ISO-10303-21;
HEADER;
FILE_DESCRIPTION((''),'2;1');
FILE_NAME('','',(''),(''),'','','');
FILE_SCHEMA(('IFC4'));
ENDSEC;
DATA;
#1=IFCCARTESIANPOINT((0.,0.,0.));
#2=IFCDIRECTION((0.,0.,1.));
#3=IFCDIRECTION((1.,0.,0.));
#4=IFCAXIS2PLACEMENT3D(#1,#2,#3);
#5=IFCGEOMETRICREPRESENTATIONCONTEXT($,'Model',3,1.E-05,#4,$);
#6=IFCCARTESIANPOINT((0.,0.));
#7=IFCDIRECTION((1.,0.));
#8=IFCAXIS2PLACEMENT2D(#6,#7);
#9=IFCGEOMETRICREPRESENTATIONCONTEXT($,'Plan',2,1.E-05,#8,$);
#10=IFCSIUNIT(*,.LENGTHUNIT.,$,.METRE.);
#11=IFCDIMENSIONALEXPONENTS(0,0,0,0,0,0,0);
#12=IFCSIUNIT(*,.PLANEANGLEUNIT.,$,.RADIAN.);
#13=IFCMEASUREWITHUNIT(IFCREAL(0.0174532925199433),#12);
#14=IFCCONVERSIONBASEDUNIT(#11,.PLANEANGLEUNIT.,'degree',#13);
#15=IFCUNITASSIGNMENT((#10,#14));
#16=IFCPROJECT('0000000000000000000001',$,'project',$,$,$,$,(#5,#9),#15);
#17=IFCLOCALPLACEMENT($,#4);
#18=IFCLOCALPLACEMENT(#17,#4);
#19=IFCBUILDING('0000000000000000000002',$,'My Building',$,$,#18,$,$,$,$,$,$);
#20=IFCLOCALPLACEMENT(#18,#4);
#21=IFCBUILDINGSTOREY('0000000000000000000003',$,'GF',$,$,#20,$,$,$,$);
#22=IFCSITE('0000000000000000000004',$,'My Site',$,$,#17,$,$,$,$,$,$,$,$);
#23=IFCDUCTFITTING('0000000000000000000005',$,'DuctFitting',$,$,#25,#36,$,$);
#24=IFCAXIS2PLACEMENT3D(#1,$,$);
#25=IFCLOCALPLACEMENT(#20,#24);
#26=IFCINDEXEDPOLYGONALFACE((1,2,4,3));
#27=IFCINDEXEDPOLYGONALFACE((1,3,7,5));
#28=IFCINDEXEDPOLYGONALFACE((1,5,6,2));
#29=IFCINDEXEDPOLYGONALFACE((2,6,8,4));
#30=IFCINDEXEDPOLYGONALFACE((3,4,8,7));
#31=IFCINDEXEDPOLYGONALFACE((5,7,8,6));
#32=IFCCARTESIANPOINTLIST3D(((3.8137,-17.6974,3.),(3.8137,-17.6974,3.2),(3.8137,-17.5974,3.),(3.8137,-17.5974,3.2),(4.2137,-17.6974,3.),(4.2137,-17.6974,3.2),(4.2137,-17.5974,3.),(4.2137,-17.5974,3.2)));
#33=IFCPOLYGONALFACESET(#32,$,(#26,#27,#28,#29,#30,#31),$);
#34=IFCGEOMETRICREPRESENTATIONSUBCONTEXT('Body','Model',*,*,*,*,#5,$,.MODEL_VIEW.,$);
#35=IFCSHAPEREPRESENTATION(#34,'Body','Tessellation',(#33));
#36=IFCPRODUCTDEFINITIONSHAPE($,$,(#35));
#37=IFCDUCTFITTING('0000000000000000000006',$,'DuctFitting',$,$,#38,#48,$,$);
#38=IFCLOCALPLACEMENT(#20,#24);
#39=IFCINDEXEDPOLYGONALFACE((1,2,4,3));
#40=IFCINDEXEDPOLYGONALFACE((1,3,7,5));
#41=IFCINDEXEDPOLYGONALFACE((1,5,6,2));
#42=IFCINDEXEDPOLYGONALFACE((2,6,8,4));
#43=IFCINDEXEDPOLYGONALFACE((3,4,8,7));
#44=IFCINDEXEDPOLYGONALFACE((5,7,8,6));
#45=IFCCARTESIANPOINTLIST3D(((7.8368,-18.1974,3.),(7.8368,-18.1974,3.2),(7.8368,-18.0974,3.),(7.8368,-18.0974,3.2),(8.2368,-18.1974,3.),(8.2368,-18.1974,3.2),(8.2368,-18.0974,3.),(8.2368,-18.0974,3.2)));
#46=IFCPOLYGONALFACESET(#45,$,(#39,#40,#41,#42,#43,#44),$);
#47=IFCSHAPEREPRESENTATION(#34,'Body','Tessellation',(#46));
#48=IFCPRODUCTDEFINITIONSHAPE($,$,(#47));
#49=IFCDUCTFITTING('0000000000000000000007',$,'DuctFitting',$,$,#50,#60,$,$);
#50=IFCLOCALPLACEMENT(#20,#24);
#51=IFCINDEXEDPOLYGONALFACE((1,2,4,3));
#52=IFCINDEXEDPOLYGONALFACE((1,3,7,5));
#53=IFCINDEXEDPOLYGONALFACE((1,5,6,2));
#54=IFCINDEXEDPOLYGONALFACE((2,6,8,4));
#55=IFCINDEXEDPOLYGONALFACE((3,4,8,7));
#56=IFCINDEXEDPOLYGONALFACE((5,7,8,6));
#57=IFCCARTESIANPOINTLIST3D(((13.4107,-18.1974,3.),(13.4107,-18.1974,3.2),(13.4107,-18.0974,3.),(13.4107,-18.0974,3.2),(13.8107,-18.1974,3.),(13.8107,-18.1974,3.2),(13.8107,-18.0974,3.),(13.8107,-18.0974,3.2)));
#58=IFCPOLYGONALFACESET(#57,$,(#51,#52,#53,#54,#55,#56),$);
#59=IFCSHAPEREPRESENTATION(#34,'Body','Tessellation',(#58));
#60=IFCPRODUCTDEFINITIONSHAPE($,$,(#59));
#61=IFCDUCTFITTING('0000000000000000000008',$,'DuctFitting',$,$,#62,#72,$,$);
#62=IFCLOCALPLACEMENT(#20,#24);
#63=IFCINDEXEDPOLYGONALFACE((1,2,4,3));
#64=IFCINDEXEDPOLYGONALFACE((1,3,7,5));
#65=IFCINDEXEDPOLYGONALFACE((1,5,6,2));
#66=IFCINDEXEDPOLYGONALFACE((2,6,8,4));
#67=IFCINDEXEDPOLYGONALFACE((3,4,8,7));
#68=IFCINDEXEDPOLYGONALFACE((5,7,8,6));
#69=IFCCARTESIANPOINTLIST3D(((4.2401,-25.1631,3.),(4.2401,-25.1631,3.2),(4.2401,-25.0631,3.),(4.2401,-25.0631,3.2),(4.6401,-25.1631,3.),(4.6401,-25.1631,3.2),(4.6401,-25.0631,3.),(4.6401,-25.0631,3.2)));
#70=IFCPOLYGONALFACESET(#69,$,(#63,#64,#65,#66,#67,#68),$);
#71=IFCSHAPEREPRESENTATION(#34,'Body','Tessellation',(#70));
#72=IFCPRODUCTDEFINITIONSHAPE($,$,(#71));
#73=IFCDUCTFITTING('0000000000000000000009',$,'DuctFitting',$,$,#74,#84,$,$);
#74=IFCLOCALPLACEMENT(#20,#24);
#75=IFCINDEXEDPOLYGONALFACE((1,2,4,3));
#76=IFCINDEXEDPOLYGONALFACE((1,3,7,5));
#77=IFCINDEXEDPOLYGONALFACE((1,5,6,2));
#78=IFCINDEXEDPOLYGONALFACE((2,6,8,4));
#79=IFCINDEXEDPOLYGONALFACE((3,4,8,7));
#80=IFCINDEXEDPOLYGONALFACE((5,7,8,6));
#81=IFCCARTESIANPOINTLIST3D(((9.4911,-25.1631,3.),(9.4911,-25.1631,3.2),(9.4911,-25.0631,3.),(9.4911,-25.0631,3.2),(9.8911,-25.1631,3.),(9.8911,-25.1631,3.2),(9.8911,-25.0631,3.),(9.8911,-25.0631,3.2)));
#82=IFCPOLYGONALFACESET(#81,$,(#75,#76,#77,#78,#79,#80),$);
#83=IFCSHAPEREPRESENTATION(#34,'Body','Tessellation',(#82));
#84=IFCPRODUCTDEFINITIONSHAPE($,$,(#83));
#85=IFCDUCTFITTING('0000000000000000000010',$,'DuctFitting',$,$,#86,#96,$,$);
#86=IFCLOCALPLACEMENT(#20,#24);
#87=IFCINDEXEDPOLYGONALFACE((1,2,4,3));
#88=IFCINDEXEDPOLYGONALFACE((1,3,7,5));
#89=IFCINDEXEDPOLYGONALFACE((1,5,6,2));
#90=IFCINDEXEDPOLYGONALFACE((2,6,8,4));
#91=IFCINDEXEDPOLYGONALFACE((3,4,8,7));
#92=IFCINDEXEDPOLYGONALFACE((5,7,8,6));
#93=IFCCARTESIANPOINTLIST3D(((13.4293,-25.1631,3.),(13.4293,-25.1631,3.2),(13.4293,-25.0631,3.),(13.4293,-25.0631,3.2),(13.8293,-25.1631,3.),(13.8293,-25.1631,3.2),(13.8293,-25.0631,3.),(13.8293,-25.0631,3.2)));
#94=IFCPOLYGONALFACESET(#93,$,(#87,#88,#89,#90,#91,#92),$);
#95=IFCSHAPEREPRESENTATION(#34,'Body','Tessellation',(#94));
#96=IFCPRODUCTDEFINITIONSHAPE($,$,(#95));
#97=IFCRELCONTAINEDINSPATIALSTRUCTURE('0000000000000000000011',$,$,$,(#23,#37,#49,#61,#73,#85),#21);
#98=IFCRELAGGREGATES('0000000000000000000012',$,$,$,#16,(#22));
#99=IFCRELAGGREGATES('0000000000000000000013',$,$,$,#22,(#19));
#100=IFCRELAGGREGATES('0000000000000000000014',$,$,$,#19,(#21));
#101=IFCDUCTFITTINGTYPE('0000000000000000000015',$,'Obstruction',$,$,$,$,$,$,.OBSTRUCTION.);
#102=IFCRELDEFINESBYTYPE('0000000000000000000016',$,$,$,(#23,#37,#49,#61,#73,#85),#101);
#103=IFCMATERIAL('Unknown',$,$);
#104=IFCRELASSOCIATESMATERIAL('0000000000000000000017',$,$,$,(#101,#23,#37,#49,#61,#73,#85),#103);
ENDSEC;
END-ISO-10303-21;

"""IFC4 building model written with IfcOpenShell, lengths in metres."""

from ifc_helpers import new_model, entity, si_unit, converted_unit, frame, origin_with_axes, origin_2d_with_axis, place, context, subcontext, project, spatial, rectangle, extrude, material, material_profile, profile_set, profile_usage, type_object, element, save


model = new_model("IFC4")

# Units and contexts
model_context = context("Model", 3, precision=1e-05, world=origin_with_axes())
plan_context = context("Plan", 2, precision=1e-05, world=origin_2d_with_axis())
body_context_1 = subcontext(model_context, "Body", "Model", "MODEL_VIEW")
ifc_project = project(units=[si_unit("LENGTHUNIT", "METRE"), converted_unit("PLANEANGLEUNIT", "degree", entity("IfcReal", 0.0174532925199433), si_unit("PLANEANGLEUNIT", "RADIAN"), dimensions=[0, 0, 0, 0, 0, 0, 0])], contexts=[model_context, plan_context])

# Site, building, storey
site_placement = place(None, origin_with_axes())
site = spatial("IfcSite", under=ifc_project, at=site_placement, Name="My Site")
building_placement = place(site_placement, origin_with_axes())
building = spatial("IfcBuilding", under=site, at=building_placement, Name="My Building")
storey_placement = place(building_placement, origin_with_axes())
storey = spatial("IfcBuildingStorey", under=building, at=storey_placement, Name="GF")

# Shared definitions
ifc_material = material(Name="Unknown")

# Duct fittings
ifc_material_profile = material_profile(ifc_material, rectangle(XDim=0.4, YDim=0.2))
ifc_profile_set = profile_set([ifc_material_profile])
duct_fitting_type = type_object("IfcDuctFittingType", Name="Obstruction", PredefinedType="OBSTRUCTION", material=ifc_profile_set)
ifc_profile_usage_1 = profile_usage(ifc_profile_set, cardinal=5)
duct_fitting_1_placement = place(storey_placement, frame((4.0137, -17.6974, 3.1), z_axis=(0.0, 1.0, -0.000003), x_axis=(-1.0, 0.0, 0.0)))
element("IfcDuctFitting", 1, at=duct_fitting_1_placement, inside=storey, type_object=duct_fitting_type, material=ifc_profile_usage_1, Name="DuctFitting", context=body_context_1, shape_type="SweptSolid", body=[
    extrude(rectangle(XDim=0.4, YDim=0.2), origin_with_axes(), (0.0, 0.0, 1.0), 0.1),
])
ifc_profile_usage_2 = profile_usage(ifc_profile_set, cardinal=5)
duct_fitting_2_placement = place(storey_placement, frame((8.0368, -18.1974, 3.1), z_axis=(0.0, 1.0, -0.000003), x_axis=(-1.0, 0.0, 0.0)))
element("IfcDuctFitting", 2, at=duct_fitting_2_placement, inside=storey, type_object=duct_fitting_type, material=ifc_profile_usage_2, Name="DuctFitting", context=body_context_1, shape_type="SweptSolid", body=[
    extrude(rectangle(XDim=0.4, YDim=0.2), origin_with_axes(), (0.0, 0.0, 1.0), 0.1),
])
ifc_profile_usage_3 = profile_usage(ifc_profile_set, cardinal=5)
duct_fitting_3_placement = place(storey_placement, frame((13.6107, -18.1974, 3.1), z_axis=(0.0, 1.0, -0.000003), x_axis=(-1.0, 0.0, 0.0)))
element("IfcDuctFitting", 3, at=duct_fitting_3_placement, inside=storey, type_object=duct_fitting_type, material=ifc_profile_usage_3, Name="DuctFitting", context=body_context_1, shape_type="SweptSolid", body=[
    extrude(rectangle(XDim=0.4, YDim=0.2), origin_with_axes(), (0.0, 0.0, 1.0), 0.1),
])
ifc_profile_usage_4 = profile_usage(ifc_profile_set, cardinal=5)
duct_fitting_4_placement = place(storey_placement, frame((4.4401, -25.1631, 3.1), z_axis=(0.0, 1.0, -0.000003), x_axis=(-1.0, 0.0, 0.0)))
element("IfcDuctFitting", 4, at=duct_fitting_4_placement, inside=storey, type_object=duct_fitting_type, material=ifc_profile_usage_4, Name="DuctFitting", context=body_context_1, shape_type="SweptSolid", body=[
    extrude(rectangle(XDim=0.4, YDim=0.2), origin_with_axes(), (0.0, 0.0, 1.0), 0.1),
])
ifc_profile_usage_5 = profile_usage(ifc_profile_set, cardinal=5)
duct_fitting_5_placement = place(storey_placement, frame((9.6911, -25.1631, 3.1), z_axis=(0.0, 1.0, -0.000003), x_axis=(-1.0, 0.0, 0.0)))
element("IfcDuctFitting", 5, at=duct_fitting_5_placement, inside=storey, type_object=duct_fitting_type, material=ifc_profile_usage_5, Name="DuctFitting", context=body_context_1, shape_type="SweptSolid", body=[
    extrude(rectangle(XDim=0.4, YDim=0.2), origin_with_axes(), (0.0, 0.0, 1.0), 0.1),
])
ifc_profile_usage_6 = profile_usage(ifc_profile_set, cardinal=5)
duct_fitting_6_placement = place(storey_placement, frame((13.6293, -25.1631, 3.1), z_axis=(0.0, 1.0, -0.000003), x_axis=(-1.0, 0.0, 0.0)))
element("IfcDuctFitting", 6, at=duct_fitting_6_placement, inside=storey, type_object=duct_fitting_type, material=ifc_profile_usage_6, Name="DuctFitting", context=body_context_1, shape_type="SweptSolid", body=[
    extrude(rectangle(XDim=0.4, YDim=0.2), origin_with_axes(), (0.0, 0.0, 1.0), 0.1),
])

save(model, "model.ifc")
